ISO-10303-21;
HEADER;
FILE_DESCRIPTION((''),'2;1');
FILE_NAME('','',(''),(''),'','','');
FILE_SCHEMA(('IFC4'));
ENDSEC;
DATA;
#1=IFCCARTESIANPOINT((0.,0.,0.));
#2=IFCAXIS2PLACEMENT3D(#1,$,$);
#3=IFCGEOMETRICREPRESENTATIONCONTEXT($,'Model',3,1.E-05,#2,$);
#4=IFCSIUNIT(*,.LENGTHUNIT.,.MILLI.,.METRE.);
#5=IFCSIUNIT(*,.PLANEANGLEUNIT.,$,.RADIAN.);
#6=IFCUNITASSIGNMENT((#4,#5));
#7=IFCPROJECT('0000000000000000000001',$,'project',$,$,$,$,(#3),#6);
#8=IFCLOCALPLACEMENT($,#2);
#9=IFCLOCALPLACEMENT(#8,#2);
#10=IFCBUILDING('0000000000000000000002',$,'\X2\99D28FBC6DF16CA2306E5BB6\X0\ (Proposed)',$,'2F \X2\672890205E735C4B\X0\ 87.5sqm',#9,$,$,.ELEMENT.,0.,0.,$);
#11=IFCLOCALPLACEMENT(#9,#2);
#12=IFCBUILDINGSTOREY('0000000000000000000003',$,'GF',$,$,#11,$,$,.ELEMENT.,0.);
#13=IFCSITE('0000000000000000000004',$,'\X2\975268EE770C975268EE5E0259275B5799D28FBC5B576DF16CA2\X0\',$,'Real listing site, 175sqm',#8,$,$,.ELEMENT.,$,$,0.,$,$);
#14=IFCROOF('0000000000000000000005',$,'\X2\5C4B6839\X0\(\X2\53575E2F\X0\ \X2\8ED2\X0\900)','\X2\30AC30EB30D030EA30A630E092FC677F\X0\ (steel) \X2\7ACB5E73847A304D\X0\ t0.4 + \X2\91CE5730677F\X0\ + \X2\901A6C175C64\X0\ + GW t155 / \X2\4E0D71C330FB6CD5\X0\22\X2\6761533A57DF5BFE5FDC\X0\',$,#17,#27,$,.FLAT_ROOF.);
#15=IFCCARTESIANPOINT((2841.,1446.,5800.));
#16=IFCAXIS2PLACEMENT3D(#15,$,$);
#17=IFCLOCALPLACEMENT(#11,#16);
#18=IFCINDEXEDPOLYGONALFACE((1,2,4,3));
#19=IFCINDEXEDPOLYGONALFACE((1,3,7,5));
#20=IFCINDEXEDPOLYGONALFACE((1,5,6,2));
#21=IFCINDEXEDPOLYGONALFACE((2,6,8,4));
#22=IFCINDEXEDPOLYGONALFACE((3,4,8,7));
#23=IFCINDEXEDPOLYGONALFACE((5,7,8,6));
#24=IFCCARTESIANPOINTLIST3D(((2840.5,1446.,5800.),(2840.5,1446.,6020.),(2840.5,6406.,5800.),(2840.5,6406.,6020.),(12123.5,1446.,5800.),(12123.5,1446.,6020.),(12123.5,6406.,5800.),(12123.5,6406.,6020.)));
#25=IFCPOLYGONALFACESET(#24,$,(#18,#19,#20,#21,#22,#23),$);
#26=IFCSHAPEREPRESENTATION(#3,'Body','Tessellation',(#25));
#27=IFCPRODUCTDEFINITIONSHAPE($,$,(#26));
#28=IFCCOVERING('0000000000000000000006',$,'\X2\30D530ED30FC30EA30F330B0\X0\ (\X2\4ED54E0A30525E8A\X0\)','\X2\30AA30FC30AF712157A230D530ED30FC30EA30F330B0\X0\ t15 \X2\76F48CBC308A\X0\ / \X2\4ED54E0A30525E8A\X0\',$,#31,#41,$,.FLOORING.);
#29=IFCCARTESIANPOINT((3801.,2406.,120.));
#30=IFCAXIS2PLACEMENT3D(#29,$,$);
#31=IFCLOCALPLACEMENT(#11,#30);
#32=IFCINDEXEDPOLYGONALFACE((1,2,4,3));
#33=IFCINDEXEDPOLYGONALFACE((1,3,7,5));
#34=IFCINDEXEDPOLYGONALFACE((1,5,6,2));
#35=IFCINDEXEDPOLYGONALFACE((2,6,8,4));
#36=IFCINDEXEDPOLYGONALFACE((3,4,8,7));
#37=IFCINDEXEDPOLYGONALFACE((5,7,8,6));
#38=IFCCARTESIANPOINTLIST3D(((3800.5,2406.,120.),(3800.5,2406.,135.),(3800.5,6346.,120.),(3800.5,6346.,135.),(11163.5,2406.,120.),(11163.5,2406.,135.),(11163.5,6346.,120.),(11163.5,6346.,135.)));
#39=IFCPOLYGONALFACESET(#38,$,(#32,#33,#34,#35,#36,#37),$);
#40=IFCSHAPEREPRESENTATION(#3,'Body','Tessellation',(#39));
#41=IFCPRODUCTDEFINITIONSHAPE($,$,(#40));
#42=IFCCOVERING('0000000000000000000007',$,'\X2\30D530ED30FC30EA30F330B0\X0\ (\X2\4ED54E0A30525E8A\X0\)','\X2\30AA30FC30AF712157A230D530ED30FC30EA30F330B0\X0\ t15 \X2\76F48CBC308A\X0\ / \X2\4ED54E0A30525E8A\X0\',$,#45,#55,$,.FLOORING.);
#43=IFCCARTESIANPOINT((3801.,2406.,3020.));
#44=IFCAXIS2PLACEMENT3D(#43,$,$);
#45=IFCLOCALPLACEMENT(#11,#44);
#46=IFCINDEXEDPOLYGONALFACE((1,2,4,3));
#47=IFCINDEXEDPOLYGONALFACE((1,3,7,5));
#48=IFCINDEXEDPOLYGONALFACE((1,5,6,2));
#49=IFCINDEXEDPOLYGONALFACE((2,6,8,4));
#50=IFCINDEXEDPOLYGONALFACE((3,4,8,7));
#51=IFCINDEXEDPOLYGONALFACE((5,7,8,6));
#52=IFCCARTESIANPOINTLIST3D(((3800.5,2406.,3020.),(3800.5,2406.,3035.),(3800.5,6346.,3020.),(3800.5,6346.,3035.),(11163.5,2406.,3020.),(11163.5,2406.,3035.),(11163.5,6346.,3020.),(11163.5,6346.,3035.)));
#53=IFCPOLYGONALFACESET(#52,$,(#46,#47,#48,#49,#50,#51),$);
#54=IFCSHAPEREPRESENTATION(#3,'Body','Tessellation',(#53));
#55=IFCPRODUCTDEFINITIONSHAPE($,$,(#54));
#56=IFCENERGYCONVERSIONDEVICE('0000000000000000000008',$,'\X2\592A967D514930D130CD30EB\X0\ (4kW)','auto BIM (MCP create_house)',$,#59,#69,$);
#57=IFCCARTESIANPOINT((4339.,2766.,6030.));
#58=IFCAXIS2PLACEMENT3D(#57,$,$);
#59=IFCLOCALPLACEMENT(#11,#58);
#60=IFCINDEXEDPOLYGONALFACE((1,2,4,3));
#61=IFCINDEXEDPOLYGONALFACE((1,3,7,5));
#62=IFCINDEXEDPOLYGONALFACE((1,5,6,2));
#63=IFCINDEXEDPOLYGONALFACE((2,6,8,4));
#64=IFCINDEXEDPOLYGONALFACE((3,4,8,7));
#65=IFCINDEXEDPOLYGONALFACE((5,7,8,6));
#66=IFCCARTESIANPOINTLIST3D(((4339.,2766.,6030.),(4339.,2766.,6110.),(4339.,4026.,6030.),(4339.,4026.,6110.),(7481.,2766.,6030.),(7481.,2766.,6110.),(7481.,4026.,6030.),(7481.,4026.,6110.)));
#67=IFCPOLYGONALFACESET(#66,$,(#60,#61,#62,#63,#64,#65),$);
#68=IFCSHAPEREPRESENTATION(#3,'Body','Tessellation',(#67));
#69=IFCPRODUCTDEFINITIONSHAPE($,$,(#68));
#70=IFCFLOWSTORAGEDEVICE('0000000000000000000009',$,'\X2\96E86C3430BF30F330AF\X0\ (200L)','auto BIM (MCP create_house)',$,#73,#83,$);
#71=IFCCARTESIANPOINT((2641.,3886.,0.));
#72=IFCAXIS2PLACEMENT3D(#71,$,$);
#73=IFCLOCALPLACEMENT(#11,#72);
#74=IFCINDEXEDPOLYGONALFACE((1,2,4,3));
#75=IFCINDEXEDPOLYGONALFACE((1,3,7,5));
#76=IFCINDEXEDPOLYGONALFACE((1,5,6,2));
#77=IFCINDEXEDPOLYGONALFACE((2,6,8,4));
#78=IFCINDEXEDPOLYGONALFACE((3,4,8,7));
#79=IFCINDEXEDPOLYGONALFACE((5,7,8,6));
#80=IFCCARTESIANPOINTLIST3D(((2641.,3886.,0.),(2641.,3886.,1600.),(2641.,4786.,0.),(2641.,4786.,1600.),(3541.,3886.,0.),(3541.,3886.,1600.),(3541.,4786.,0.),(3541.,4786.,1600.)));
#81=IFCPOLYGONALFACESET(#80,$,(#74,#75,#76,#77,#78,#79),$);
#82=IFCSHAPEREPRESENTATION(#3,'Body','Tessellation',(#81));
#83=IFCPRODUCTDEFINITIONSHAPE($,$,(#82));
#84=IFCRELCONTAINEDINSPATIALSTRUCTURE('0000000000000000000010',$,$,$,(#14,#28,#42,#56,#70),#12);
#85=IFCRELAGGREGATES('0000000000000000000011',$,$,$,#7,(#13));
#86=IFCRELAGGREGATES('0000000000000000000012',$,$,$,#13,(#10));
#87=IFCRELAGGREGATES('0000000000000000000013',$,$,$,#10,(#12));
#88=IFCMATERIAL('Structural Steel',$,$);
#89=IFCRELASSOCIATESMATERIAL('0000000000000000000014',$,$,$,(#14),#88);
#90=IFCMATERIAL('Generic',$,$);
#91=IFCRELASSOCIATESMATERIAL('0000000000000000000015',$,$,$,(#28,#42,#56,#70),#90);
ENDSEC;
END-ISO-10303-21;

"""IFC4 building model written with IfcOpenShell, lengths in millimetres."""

from ifc_helpers import new_model, si_unit, frame, frame_2d, origin, place, context, project, spatial, rectangle, extrude, material, element, save


model = new_model("IFC4")

# Units and contexts
model_context = context("Model", 3, precision=1e-05, world=origin())
ifc_project = project(units=[si_unit("LENGTHUNIT", "METRE", prefix="MILLI"), si_unit("PLANEANGLEUNIT", "RADIAN")], contexts=[model_context])

# Site, building, storey
site_placement = place(None, origin())
site = spatial("IfcSite", under=ifc_project, at=site_placement, Name="青森県青森市大字駒込字深沢", ObjectType="Real listing site, 175sqm", CompositionType="ELEMENT", RefElevation=0.0)
building_placement = place(site_placement, origin())
building = spatial("IfcBuilding", under=site, at=building_placement, Name="駒込深沢の家 (Proposed)", ObjectType="2F 木造平屋 87.5sqm", CompositionType="ELEMENT", ElevationOfRefHeight=0.0, ElevationOfTerrain=0.0)
storey_placement = place(building_placement, origin())
storey = spatial("IfcBuildingStorey", under=building, at=storey_placement, Name="GF", CompositionType="ELEMENT", Elevation=0.0)

# Roof
ifc_material_1 = material(Name="Structural Steel")
for number, where, name in (
    (1, (2841.0, 1446.0, 5800.0), "屋根(南帯 軒900)"),
):
    element("IfcRoof", number, at=place(storey_placement, frame(where)), inside=storey, material=ifc_material_1, Name=name, Description="ガルバリウム鋼板 (steel) 立平葺き t0.4 + 野地板 + 通気層 + GW t155 / 不燃・法22条区域対応", PredefinedType="FLAT_ROOF", context=model_context, shape_type="SweptSolid", body=[
        extrude(rectangle(XDim=9283.0, YDim=4960.0, at=frame_2d((4641.0, 2480.0))), frame((2841.0, 1446.0, 5800.0)), (0.0, 0.0, 1.0), 220.0),
    ])

# Coverings
ifc_material_2 = material(Name="Generic")
covering_1_placement = place(storey_placement, frame((3801.0, 2406.0, 120.0)))
element("IfcCovering", 2, at=covering_1_placement, inside=storey, material=ifc_material_2, Name="フローリング (仕上げ床)", Description="オーク無垢フローリング t15 直貼り / 仕上げ床", PredefinedType="FLOORING", context=model_context, shape_type="SweptSolid", body=[
    extrude(rectangle(XDim=7363.0, YDim=3940.0, at=frame_2d((3681.0, 1970.0))), frame((3801.0, 2406.0, 120.0)), (0.0, 0.0, 1.0), 15.0),
])
covering_2_placement = place(storey_placement, frame((3801.0, 2406.0, 3020.0)))
element("IfcCovering", 3, at=covering_2_placement, inside=storey, material=ifc_material_2, Name="フローリング (仕上げ床)", Description="オーク無垢フローリング t15 直貼り / 仕上げ床", PredefinedType="FLOORING", context=model_context, shape_type="SweptSolid", body=[
    extrude(rectangle(XDim=7363.0, YDim=3940.0, at=frame_2d((3681.0, 1970.0))), frame((3801.0, 2406.0, 3020.0)), (0.0, 0.0, 1.0), 15.0),
])

# Energy conversion device
energy_conversion_device_placement = place(storey_placement, frame((4339.0, 2766.0, 6030.0)))
element("IfcEnergyConversionDevice", 4, at=energy_conversion_device_placement, inside=storey, material=ifc_material_2, Name="太陽光パネル (4kW)", Description="auto BIM (MCP create_house)", context=model_context, shape_type="SweptSolid", body=[
    extrude(rectangle(XDim=3142.0, YDim=1260.0, at=frame_2d((1571.0, 630.0))), frame((4339.0, 2766.0, 6030.0)), (0.0, 0.0, 1.0), 80.0),
])

# Flow storage device
flow_storage_device_placement = place(storey_placement, frame((2641.0, 3886.0, 0.0)))
element("IfcFlowStorageDevice", 5, at=flow_storage_device_placement, inside=storey, material=ifc_material_2, Name="雨水タンク (200L)", Description="auto BIM (MCP create_house)", context=model_context, shape_type="SweptSolid", body=[
    extrude(rectangle(XDim=900.0, YDim=900.0, at=frame_2d((450.0, 450.0))), frame((2641.0, 3886.0, 0.0)), (0.0, 0.0, 1.0), 1600.0),
])

save(model, "model.ifc")
